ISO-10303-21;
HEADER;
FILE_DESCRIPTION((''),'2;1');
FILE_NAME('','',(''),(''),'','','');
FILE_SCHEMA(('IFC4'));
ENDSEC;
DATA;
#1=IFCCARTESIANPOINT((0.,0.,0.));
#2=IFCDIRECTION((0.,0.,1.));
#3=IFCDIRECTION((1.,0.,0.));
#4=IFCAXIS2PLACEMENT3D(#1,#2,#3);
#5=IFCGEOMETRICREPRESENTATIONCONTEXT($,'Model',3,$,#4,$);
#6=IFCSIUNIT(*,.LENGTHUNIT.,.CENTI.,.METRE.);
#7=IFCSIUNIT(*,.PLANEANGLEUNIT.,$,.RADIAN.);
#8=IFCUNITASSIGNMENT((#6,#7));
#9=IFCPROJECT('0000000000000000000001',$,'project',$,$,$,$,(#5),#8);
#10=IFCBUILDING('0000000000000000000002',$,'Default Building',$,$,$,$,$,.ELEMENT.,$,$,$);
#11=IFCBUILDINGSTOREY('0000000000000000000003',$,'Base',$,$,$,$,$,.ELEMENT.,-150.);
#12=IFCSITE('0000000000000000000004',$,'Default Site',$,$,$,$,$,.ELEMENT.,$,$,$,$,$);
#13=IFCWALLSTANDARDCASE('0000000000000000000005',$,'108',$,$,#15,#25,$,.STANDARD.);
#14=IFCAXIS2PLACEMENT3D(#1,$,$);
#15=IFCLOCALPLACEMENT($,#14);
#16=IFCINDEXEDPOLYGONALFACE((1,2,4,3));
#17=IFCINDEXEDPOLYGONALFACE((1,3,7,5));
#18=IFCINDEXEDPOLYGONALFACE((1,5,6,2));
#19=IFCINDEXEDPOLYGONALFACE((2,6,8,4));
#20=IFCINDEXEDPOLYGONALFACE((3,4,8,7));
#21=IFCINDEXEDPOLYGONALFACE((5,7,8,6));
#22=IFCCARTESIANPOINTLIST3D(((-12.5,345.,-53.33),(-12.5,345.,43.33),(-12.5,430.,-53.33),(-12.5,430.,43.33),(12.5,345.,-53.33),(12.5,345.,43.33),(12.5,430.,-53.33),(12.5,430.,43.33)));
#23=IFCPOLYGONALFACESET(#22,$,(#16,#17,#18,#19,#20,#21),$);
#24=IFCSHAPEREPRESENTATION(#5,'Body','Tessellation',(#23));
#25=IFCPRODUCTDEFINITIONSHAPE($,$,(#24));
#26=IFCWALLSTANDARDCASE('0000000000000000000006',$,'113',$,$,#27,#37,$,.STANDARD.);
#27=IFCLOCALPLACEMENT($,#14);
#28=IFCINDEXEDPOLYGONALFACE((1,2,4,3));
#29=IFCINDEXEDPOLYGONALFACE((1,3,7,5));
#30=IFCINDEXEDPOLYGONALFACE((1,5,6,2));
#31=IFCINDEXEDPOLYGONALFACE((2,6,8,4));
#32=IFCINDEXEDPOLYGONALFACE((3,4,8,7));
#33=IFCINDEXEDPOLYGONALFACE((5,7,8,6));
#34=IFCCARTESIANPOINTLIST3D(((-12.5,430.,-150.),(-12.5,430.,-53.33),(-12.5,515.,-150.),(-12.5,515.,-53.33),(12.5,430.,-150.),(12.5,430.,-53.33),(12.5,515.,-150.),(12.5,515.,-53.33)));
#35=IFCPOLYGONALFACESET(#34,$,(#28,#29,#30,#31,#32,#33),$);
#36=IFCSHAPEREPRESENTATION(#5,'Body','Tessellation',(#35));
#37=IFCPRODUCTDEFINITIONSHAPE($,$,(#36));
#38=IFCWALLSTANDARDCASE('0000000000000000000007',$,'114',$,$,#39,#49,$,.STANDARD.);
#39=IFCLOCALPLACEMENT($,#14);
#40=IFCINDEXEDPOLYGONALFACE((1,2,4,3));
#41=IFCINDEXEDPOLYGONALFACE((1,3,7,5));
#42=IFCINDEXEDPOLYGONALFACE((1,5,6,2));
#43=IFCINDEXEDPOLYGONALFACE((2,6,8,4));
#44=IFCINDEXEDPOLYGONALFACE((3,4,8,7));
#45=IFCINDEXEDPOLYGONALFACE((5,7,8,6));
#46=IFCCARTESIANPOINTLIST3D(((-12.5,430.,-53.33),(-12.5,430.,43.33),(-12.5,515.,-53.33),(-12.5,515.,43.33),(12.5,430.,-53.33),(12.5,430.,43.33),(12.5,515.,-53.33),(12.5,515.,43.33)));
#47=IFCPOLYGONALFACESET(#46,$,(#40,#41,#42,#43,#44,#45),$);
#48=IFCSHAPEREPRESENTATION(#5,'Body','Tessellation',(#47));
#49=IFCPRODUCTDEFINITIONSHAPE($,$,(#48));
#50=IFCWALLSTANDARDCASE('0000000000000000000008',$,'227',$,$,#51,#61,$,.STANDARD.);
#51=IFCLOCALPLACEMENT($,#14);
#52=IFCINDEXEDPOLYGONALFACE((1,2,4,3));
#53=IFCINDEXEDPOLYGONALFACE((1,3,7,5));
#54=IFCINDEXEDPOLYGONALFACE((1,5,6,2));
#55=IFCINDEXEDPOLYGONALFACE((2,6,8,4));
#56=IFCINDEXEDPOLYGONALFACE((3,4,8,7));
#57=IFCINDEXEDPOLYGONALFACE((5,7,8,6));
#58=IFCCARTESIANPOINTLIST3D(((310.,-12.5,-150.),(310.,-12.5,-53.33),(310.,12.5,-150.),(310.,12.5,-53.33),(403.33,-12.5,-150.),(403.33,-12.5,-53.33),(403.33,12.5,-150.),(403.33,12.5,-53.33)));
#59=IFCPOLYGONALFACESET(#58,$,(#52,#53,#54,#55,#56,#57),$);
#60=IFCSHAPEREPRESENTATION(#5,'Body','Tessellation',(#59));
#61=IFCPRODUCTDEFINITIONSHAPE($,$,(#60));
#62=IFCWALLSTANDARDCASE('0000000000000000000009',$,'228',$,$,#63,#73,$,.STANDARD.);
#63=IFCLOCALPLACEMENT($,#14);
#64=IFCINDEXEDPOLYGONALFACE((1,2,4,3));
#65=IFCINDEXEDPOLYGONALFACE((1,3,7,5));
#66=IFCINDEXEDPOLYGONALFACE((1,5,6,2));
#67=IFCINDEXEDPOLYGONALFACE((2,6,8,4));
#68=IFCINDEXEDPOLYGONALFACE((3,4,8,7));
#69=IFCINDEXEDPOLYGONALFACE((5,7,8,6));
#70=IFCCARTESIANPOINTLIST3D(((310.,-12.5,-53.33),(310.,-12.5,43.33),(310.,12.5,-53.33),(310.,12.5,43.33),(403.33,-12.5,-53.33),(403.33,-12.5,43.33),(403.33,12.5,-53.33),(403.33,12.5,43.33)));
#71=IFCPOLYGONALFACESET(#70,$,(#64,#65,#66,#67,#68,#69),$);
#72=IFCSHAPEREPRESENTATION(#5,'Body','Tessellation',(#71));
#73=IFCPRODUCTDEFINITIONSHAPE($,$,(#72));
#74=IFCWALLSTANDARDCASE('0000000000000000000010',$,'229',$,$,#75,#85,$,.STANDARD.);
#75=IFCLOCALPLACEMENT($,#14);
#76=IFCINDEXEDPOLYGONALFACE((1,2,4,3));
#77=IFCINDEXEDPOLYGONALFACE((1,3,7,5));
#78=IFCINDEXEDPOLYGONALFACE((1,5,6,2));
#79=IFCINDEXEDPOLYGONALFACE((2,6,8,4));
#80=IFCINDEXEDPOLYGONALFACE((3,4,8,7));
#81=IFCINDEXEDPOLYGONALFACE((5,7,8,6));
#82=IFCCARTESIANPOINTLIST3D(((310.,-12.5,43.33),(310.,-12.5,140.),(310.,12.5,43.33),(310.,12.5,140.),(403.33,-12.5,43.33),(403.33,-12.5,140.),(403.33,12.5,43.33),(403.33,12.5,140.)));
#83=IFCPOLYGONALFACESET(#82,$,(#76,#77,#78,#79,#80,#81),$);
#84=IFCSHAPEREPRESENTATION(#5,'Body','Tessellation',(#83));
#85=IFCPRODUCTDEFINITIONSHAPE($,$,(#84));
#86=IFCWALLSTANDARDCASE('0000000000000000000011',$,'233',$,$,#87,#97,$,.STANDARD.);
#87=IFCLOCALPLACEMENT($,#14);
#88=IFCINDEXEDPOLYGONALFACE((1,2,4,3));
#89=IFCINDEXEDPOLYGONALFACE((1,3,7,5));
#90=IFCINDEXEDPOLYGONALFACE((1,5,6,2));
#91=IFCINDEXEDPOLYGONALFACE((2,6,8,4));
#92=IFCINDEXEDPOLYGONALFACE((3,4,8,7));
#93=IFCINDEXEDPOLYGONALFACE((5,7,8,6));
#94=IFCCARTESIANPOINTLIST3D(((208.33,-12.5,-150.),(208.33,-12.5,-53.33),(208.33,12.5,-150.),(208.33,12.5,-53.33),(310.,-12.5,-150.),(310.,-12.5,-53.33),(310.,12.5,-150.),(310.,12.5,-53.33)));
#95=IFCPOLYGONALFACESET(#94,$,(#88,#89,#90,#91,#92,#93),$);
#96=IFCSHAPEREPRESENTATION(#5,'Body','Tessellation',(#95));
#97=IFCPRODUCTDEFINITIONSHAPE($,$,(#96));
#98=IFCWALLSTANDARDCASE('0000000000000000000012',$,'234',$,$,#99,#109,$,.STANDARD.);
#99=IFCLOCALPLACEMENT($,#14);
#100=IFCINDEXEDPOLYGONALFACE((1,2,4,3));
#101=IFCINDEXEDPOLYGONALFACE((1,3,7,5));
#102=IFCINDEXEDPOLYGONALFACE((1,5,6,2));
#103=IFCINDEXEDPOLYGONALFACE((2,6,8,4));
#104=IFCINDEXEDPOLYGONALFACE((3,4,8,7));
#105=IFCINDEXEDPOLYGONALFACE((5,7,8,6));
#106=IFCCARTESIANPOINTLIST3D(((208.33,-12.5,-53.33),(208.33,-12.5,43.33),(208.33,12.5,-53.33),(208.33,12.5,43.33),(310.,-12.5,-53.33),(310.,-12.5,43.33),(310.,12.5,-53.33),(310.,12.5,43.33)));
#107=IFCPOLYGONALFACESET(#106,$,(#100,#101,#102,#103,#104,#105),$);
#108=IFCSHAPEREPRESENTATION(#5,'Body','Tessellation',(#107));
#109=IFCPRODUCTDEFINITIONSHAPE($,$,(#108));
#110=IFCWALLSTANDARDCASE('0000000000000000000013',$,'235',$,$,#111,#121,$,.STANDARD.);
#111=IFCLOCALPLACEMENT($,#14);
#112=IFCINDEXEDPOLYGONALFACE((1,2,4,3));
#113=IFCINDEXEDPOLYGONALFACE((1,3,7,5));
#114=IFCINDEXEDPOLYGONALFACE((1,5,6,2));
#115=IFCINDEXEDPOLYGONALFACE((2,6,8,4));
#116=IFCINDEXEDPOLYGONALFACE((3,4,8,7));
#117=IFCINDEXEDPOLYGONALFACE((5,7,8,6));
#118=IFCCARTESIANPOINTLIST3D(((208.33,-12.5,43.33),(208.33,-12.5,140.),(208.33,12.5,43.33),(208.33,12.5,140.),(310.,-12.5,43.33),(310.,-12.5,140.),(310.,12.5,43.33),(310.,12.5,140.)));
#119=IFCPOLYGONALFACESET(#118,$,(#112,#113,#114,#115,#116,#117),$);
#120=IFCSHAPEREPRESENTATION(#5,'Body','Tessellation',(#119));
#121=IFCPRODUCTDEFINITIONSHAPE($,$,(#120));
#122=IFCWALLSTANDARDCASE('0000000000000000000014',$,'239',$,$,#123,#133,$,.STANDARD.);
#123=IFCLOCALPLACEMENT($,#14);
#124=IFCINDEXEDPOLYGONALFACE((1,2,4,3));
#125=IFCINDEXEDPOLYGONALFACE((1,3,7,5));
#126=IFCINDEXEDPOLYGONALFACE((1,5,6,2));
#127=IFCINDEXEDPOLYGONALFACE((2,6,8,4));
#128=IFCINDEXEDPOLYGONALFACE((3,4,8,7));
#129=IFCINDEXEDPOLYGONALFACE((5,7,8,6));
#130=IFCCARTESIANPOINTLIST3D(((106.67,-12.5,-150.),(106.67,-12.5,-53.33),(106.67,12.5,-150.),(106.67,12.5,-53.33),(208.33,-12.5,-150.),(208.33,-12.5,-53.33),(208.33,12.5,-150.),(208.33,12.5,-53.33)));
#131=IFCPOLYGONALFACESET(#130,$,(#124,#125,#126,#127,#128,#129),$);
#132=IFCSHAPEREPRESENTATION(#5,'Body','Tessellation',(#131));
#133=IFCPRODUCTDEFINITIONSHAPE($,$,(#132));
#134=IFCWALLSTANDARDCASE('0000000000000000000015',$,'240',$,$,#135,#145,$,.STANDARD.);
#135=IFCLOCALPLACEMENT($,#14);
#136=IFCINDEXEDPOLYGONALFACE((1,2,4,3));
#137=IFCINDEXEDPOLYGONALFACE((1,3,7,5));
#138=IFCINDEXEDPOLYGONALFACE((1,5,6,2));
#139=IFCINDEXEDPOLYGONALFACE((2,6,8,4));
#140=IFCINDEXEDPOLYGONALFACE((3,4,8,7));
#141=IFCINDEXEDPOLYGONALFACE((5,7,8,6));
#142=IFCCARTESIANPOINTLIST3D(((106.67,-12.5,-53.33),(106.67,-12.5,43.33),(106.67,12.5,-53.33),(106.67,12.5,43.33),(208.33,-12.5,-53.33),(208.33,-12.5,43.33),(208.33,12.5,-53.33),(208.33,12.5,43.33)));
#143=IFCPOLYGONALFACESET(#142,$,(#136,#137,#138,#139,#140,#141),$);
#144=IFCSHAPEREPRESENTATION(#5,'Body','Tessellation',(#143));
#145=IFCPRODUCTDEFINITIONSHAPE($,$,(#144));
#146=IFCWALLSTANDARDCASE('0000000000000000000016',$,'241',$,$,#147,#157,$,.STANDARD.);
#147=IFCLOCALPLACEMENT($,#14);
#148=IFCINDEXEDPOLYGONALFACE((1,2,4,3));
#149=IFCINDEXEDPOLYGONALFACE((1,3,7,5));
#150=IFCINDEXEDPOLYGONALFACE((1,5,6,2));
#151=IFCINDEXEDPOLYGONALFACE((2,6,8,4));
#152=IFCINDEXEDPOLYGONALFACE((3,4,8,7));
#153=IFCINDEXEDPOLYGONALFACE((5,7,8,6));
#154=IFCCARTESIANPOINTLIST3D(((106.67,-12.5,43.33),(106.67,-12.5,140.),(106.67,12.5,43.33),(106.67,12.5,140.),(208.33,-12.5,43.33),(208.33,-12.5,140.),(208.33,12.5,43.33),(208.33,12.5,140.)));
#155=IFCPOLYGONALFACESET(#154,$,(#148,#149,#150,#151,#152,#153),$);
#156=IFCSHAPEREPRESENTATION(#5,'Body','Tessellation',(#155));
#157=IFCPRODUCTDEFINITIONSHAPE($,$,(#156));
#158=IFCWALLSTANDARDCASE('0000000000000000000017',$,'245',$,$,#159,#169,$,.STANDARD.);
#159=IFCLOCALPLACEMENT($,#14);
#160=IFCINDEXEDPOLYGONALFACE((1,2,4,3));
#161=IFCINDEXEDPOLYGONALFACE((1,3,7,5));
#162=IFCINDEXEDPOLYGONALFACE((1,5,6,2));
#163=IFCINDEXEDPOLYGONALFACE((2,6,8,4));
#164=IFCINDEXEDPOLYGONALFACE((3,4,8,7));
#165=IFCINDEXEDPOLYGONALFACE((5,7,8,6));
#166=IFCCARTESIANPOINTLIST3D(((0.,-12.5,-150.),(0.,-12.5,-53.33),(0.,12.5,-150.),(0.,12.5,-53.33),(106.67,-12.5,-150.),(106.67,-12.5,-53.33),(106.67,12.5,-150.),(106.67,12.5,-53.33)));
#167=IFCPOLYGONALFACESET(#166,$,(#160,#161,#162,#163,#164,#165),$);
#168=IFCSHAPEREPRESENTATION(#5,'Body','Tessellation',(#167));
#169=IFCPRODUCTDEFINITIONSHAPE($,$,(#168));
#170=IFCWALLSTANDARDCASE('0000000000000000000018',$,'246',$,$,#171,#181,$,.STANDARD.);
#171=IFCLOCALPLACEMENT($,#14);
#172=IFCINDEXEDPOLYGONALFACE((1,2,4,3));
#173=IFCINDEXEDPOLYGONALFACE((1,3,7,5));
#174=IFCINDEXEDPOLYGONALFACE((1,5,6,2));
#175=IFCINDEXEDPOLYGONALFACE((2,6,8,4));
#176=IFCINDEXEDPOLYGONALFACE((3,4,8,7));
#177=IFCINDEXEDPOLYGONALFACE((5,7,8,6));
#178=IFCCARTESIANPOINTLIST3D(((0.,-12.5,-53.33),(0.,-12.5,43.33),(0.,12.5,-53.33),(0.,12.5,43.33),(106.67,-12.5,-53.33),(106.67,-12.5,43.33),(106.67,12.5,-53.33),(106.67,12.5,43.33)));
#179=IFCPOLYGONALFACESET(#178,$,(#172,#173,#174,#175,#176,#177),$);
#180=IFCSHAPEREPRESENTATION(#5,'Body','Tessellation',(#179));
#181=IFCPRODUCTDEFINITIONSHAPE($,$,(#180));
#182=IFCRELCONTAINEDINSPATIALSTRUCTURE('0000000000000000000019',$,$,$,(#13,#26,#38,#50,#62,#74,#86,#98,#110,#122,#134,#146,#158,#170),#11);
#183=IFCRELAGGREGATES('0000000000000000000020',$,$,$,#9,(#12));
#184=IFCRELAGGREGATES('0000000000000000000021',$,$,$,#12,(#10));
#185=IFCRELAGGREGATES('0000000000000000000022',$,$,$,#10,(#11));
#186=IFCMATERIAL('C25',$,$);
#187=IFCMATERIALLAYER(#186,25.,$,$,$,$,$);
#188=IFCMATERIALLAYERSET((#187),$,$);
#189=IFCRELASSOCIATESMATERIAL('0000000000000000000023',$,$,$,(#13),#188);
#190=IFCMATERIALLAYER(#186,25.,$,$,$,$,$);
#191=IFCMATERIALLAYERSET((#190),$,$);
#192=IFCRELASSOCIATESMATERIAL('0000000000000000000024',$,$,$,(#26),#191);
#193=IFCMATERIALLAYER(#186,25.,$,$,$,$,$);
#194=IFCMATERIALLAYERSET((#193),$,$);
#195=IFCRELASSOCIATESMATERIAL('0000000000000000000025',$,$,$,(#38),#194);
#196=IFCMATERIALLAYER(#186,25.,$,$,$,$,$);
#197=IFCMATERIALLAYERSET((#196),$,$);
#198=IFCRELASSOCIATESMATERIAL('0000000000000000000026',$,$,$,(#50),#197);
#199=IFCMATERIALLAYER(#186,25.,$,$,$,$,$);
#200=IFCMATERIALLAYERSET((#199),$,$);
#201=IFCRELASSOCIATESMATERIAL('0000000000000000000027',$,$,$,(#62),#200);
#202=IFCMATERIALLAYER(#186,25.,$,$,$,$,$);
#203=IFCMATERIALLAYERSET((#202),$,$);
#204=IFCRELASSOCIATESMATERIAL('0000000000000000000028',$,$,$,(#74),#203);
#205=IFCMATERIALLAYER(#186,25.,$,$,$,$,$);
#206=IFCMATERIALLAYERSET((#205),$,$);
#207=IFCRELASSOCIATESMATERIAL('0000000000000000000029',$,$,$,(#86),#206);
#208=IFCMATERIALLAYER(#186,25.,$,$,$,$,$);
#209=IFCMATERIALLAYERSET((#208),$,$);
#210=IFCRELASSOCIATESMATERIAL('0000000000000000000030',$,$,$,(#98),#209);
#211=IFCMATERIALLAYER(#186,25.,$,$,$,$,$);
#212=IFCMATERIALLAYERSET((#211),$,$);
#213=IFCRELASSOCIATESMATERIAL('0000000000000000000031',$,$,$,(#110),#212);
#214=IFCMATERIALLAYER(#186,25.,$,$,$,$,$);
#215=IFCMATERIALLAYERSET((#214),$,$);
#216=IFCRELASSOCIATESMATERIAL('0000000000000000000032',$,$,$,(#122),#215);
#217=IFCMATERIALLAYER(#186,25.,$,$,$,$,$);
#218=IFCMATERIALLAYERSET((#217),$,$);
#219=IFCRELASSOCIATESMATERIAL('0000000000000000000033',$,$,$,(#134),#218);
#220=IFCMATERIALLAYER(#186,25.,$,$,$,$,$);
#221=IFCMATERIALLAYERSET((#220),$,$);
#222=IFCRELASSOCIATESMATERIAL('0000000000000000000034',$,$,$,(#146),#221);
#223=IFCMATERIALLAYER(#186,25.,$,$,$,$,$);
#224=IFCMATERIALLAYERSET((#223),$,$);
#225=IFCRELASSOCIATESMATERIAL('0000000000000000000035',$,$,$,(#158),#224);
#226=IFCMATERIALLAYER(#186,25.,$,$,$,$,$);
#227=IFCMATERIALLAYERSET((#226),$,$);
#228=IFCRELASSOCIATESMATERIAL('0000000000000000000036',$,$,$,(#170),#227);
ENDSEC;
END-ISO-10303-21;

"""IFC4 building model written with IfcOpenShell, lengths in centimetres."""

from ifc_helpers import new_model, si_unit, frame, origin_with_axes, origin_2d_with_axis, place, context, project, spatial, rectangle, extrude, material, layer, layer_set, layer_usage, element, save


model = new_model("IFC4")

# Units and contexts
model_context = context("Model", 3, world=origin_with_axes())
ifc_project = project(units=[si_unit("LENGTHUNIT", "METRE", prefix="CENTI"), si_unit("PLANEANGLEUNIT", "RADIAN")], contexts=[model_context])

# Site, building, storey
site = spatial("IfcSite", under=ifc_project, Name="Default Site", CompositionType="ELEMENT")
building = spatial("IfcBuilding", under=site, Name="Default Building", CompositionType="ELEMENT")
storey = spatial("IfcBuildingStorey", under=building, Name="Base", CompositionType="ELEMENT", Elevation=-150.0)

# Shared definitions
ifc_material = material(Name="C25")

# Walls
ifc_layer_1 = layer(ifc_material, 25.0)
ifc_layer_set_1 = layer_set([ifc_layer_1])
ifc_layer_usage_1 = layer_usage(ifc_layer_set_1, "AXIS2", "POSITIVE", -25.0)
wall_1_placement = place(None, frame((0.0, 387.5, -53.33), z_axis=(0.0, 0.0, 1.0), x_axis=(0.0, 1.0, 0.0)))
element("IfcWallStandardCase", 1, at=wall_1_placement, inside=storey, material=ifc_layer_usage_1, Name="108", PredefinedType="STANDARD", context=model_context, shape_type="SweptSolid", body=[
    extrude(rectangle(XDim=85.0, YDim=25.0, at=origin_2d_with_axis()), origin_with_axes(), (0.0, 0.0, 1.0), 96.67),
])
ifc_layer_2 = layer(ifc_material, 25.0)
ifc_layer_set_2 = layer_set([ifc_layer_2])
ifc_layer_usage_2 = layer_usage(ifc_layer_set_2, "AXIS2", "POSITIVE", -25.0)
wall_2_placement = place(None, frame((0.0, 472.5, -150.0), z_axis=(0.0, 0.0, 1.0), x_axis=(0.0, 1.0, 0.0)))
element("IfcWallStandardCase", 2, at=wall_2_placement, inside=storey, material=ifc_layer_usage_2, Name="113", PredefinedType="STANDARD", context=model_context, shape_type="SweptSolid", body=[
    extrude(rectangle(XDim=85.0, YDim=25.0, at=origin_2d_with_axis()), origin_with_axes(), (0.0, 0.0, 1.0), 96.67),
])
ifc_layer_3 = layer(ifc_material, 25.0)
ifc_layer_set_3 = layer_set([ifc_layer_3])
ifc_layer_usage_3 = layer_usage(ifc_layer_set_3, "AXIS2", "POSITIVE", -25.0)
wall_3_placement = place(None, frame((0.0, 472.5, -53.33), z_axis=(0.0, 0.0, 1.0), x_axis=(0.0, 1.0, 0.0)))
element("IfcWallStandardCase", 3, at=wall_3_placement, inside=storey, material=ifc_layer_usage_3, Name="114", PredefinedType="STANDARD", context=model_context, shape_type="SweptSolid", body=[
    extrude(rectangle(XDim=85.0, YDim=25.0, at=origin_2d_with_axis()), origin_with_axes(), (0.0, 0.0, 1.0), 96.67),
])
ifc_layer_4 = layer(ifc_material, 25.0)
ifc_layer_set_4 = layer_set([ifc_layer_4])
ifc_layer_usage_4 = layer_usage(ifc_layer_set_4, "AXIS2", "POSITIVE", -25.0)
wall_4_placement = place(None, frame((356.67, 0.0, -150.0), z_axis=(0.0, 0.0, 1.0), x_axis=(-1.0, 0.0, 0.0)))
element("IfcWallStandardCase", 4, at=wall_4_placement, inside=storey, material=ifc_layer_usage_4, Name="227", PredefinedType="STANDARD", context=model_context, shape_type="SweptSolid", body=[
    extrude(rectangle(XDim=93.33, YDim=25.0, at=origin_2d_with_axis()), origin_with_axes(), (0.0, 0.0, 1.0), 96.67),
])
ifc_layer_5 = layer(ifc_material, 25.0)
ifc_layer_set_5 = layer_set([ifc_layer_5])
ifc_layer_usage_5 = layer_usage(ifc_layer_set_5, "AXIS2", "POSITIVE", -25.0)
wall_5_placement = place(None, frame((356.67, 0.0, -53.33), z_axis=(0.0, 0.0, 1.0), x_axis=(-1.0, 0.0, 0.0)))
element("IfcWallStandardCase", 5, at=wall_5_placement, inside=storey, material=ifc_layer_usage_5, Name="228", PredefinedType="STANDARD", context=model_context, shape_type="SweptSolid", body=[
    extrude(rectangle(XDim=93.33, YDim=25.0, at=origin_2d_with_axis()), origin_with_axes(), (0.0, 0.0, 1.0), 96.67),
])
ifc_layer_6 = layer(ifc_material, 25.0)
ifc_layer_set_6 = layer_set([ifc_layer_6])
ifc_layer_usage_6 = layer_usage(ifc_layer_set_6, "AXIS2", "POSITIVE", -25.0)
wall_6_placement = place(None, frame((356.67, 0.0, 43.33), z_axis=(0.0, 0.0, 1.0), x_axis=(-1.0, 0.0, 0.0)))
element("IfcWallStandardCase", 6, at=wall_6_placement, inside=storey, material=ifc_layer_usage_6, Name="229", PredefinedType="STANDARD", context=model_context, shape_type="SweptSolid", body=[
    extrude(rectangle(XDim=93.33, YDim=25.0, at=origin_2d_with_axis()), origin_with_axes(), (0.0, 0.0, 1.0), 96.67),
])
ifc_layer_7 = layer(ifc_material, 25.0)
ifc_layer_set_7 = layer_set([ifc_layer_7])
ifc_layer_usage_7 = layer_usage(ifc_layer_set_7, "AXIS2", "POSITIVE", -25.0)
wall_7_placement = place(None, frame((259.17, 0.0, -150.0), z_axis=(0.0, 0.0, 1.0), x_axis=(-1.0, 0.0, 0.0)))
element("IfcWallStandardCase", 7, at=wall_7_placement, inside=storey, material=ifc_layer_usage_7, Name="233", PredefinedType="STANDARD", context=model_context, shape_type="SweptSolid", body=[
    extrude(rectangle(XDim=101.67, YDim=25.0, at=origin_2d_with_axis()), origin_with_axes(), (0.0, 0.0, 1.0), 96.67),
])
ifc_layer_8 = layer(ifc_material, 25.0)
ifc_layer_set_8 = layer_set([ifc_layer_8])
ifc_layer_usage_8 = layer_usage(ifc_layer_set_8, "AXIS2", "POSITIVE", -25.0)
wall_8_placement = place(None, frame((259.17, 0.0, -53.33), z_axis=(0.0, 0.0, 1.0), x_axis=(-1.0, 0.0, 0.0)))
element("IfcWallStandardCase", 8, at=wall_8_placement, inside=storey, material=ifc_layer_usage_8, Name="234", PredefinedType="STANDARD", context=model_context, shape_type="SweptSolid", body=[
    extrude(rectangle(XDim=101.67, YDim=25.0, at=origin_2d_with_axis()), origin_with_axes(), (0.0, 0.0, 1.0), 96.67),
])
ifc_layer_9 = layer(ifc_material, 25.0)
ifc_layer_set_9 = layer_set([ifc_layer_9])
ifc_layer_usage_9 = layer_usage(ifc_layer_set_9, "AXIS2", "POSITIVE", -25.0)
wall_9_placement = place(None, frame((259.17, 0.0, 43.33), z_axis=(0.0, 0.0, 1.0), x_axis=(-1.0, 0.0, 0.0)))
element("IfcWallStandardCase", 9, at=wall_9_placement, inside=storey, material=ifc_layer_usage_9, Name="235", PredefinedType="STANDARD", context=model_context, shape_type="SweptSolid", body=[
    extrude(rectangle(XDim=101.67, YDim=25.0, at=origin_2d_with_axis()), origin_with_axes(), (0.0, 0.0, 1.0), 96.67),
])
ifc_layer_10 = layer(ifc_material, 25.0)
ifc_layer_set_10 = layer_set([ifc_layer_10])
ifc_layer_usage_10 = layer_usage(ifc_layer_set_10, "AXIS2", "POSITIVE", -25.0)
wall_10_placement = place(None, frame((157.5, 0.0, -150.0), z_axis=(0.0, 0.0, 1.0), x_axis=(-1.0, 0.0, 0.0)))
element("IfcWallStandardCase", 10, at=wall_10_placement, inside=storey, material=ifc_layer_usage_10, Name="239", PredefinedType="STANDARD", context=model_context, shape_type="SweptSolid", body=[
    extrude(rectangle(XDim=101.67, YDim=25.0, at=origin_2d_with_axis()), origin_with_axes(), (0.0, 0.0, 1.0), 96.67),
])
ifc_layer_11 = layer(ifc_material, 25.0)
ifc_layer_set_11 = layer_set([ifc_layer_11])
ifc_layer_usage_11 = layer_usage(ifc_layer_set_11, "AXIS2", "POSITIVE", -25.0)
wall_11_placement = place(None, frame((157.5, 0.0, -53.33), z_axis=(0.0, 0.0, 1.0), x_axis=(-1.0, 0.0, 0.0)))
element("IfcWallStandardCase", 11, at=wall_11_placement, inside=storey, material=ifc_layer_usage_11, Name="240", PredefinedType="STANDARD", context=model_context, shape_type="SweptSolid", body=[
    extrude(rectangle(XDim=101.67, YDim=25.0, at=origin_2d_with_axis()), origin_with_axes(), (0.0, 0.0, 1.0), 96.67),
])
ifc_layer_12 = layer(ifc_material, 25.0)
ifc_layer_set_12 = layer_set([ifc_layer_12])
ifc_layer_usage_12 = layer_usage(ifc_layer_set_12, "AXIS2", "POSITIVE", -25.0)
wall_12_placement = place(None, frame((157.5, 0.0, 43.33), z_axis=(0.0, 0.0, 1.0), x_axis=(-1.0, 0.0, 0.0)))
element("IfcWallStandardCase", 12, at=wall_12_placement, inside=storey, material=ifc_layer_usage_12, Name="241", PredefinedType="STANDARD", context=model_context, shape_type="SweptSolid", body=[
    extrude(rectangle(XDim=101.67, YDim=25.0, at=origin_2d_with_axis()), origin_with_axes(), (0.0, 0.0, 1.0), 96.67),
])
ifc_layer_13 = layer(ifc_material, 25.0)
ifc_layer_set_13 = layer_set([ifc_layer_13])
ifc_layer_usage_13 = layer_usage(ifc_layer_set_13, "AXIS2", "POSITIVE", -25.0)
wall_13_placement = place(None, frame((53.33, 0.0, -150.0), z_axis=(0.0, 0.0, 1.0), x_axis=(-1.0, 0.0, 0.0)))
element("IfcWallStandardCase", 13, at=wall_13_placement, inside=storey, material=ifc_layer_usage_13, Name="245", PredefinedType="STANDARD", context=model_context, shape_type="SweptSolid", body=[
    extrude(rectangle(XDim=106.67, YDim=25.0, at=origin_2d_with_axis()), origin_with_axes(), (0.0, 0.0, 1.0), 96.67),
])
ifc_layer_14 = layer(ifc_material, 25.0)
ifc_layer_set_14 = layer_set([ifc_layer_14])
ifc_layer_usage_14 = layer_usage(ifc_layer_set_14, "AXIS2", "POSITIVE", -25.0)
wall_14_placement = place(None, frame((53.33, 0.0, -53.33), z_axis=(0.0, 0.0, 1.0), x_axis=(-1.0, 0.0, 0.0)))
element("IfcWallStandardCase", 14, at=wall_14_placement, inside=storey, material=ifc_layer_usage_14, Name="246", PredefinedType="STANDARD", context=model_context, shape_type="SweptSolid", body=[
    extrude(rectangle(XDim=106.67, YDim=25.0, at=origin_2d_with_axis()), origin_with_axes(), (0.0, 0.0, 1.0), 96.67),
])

save(model, "model.ifc")
